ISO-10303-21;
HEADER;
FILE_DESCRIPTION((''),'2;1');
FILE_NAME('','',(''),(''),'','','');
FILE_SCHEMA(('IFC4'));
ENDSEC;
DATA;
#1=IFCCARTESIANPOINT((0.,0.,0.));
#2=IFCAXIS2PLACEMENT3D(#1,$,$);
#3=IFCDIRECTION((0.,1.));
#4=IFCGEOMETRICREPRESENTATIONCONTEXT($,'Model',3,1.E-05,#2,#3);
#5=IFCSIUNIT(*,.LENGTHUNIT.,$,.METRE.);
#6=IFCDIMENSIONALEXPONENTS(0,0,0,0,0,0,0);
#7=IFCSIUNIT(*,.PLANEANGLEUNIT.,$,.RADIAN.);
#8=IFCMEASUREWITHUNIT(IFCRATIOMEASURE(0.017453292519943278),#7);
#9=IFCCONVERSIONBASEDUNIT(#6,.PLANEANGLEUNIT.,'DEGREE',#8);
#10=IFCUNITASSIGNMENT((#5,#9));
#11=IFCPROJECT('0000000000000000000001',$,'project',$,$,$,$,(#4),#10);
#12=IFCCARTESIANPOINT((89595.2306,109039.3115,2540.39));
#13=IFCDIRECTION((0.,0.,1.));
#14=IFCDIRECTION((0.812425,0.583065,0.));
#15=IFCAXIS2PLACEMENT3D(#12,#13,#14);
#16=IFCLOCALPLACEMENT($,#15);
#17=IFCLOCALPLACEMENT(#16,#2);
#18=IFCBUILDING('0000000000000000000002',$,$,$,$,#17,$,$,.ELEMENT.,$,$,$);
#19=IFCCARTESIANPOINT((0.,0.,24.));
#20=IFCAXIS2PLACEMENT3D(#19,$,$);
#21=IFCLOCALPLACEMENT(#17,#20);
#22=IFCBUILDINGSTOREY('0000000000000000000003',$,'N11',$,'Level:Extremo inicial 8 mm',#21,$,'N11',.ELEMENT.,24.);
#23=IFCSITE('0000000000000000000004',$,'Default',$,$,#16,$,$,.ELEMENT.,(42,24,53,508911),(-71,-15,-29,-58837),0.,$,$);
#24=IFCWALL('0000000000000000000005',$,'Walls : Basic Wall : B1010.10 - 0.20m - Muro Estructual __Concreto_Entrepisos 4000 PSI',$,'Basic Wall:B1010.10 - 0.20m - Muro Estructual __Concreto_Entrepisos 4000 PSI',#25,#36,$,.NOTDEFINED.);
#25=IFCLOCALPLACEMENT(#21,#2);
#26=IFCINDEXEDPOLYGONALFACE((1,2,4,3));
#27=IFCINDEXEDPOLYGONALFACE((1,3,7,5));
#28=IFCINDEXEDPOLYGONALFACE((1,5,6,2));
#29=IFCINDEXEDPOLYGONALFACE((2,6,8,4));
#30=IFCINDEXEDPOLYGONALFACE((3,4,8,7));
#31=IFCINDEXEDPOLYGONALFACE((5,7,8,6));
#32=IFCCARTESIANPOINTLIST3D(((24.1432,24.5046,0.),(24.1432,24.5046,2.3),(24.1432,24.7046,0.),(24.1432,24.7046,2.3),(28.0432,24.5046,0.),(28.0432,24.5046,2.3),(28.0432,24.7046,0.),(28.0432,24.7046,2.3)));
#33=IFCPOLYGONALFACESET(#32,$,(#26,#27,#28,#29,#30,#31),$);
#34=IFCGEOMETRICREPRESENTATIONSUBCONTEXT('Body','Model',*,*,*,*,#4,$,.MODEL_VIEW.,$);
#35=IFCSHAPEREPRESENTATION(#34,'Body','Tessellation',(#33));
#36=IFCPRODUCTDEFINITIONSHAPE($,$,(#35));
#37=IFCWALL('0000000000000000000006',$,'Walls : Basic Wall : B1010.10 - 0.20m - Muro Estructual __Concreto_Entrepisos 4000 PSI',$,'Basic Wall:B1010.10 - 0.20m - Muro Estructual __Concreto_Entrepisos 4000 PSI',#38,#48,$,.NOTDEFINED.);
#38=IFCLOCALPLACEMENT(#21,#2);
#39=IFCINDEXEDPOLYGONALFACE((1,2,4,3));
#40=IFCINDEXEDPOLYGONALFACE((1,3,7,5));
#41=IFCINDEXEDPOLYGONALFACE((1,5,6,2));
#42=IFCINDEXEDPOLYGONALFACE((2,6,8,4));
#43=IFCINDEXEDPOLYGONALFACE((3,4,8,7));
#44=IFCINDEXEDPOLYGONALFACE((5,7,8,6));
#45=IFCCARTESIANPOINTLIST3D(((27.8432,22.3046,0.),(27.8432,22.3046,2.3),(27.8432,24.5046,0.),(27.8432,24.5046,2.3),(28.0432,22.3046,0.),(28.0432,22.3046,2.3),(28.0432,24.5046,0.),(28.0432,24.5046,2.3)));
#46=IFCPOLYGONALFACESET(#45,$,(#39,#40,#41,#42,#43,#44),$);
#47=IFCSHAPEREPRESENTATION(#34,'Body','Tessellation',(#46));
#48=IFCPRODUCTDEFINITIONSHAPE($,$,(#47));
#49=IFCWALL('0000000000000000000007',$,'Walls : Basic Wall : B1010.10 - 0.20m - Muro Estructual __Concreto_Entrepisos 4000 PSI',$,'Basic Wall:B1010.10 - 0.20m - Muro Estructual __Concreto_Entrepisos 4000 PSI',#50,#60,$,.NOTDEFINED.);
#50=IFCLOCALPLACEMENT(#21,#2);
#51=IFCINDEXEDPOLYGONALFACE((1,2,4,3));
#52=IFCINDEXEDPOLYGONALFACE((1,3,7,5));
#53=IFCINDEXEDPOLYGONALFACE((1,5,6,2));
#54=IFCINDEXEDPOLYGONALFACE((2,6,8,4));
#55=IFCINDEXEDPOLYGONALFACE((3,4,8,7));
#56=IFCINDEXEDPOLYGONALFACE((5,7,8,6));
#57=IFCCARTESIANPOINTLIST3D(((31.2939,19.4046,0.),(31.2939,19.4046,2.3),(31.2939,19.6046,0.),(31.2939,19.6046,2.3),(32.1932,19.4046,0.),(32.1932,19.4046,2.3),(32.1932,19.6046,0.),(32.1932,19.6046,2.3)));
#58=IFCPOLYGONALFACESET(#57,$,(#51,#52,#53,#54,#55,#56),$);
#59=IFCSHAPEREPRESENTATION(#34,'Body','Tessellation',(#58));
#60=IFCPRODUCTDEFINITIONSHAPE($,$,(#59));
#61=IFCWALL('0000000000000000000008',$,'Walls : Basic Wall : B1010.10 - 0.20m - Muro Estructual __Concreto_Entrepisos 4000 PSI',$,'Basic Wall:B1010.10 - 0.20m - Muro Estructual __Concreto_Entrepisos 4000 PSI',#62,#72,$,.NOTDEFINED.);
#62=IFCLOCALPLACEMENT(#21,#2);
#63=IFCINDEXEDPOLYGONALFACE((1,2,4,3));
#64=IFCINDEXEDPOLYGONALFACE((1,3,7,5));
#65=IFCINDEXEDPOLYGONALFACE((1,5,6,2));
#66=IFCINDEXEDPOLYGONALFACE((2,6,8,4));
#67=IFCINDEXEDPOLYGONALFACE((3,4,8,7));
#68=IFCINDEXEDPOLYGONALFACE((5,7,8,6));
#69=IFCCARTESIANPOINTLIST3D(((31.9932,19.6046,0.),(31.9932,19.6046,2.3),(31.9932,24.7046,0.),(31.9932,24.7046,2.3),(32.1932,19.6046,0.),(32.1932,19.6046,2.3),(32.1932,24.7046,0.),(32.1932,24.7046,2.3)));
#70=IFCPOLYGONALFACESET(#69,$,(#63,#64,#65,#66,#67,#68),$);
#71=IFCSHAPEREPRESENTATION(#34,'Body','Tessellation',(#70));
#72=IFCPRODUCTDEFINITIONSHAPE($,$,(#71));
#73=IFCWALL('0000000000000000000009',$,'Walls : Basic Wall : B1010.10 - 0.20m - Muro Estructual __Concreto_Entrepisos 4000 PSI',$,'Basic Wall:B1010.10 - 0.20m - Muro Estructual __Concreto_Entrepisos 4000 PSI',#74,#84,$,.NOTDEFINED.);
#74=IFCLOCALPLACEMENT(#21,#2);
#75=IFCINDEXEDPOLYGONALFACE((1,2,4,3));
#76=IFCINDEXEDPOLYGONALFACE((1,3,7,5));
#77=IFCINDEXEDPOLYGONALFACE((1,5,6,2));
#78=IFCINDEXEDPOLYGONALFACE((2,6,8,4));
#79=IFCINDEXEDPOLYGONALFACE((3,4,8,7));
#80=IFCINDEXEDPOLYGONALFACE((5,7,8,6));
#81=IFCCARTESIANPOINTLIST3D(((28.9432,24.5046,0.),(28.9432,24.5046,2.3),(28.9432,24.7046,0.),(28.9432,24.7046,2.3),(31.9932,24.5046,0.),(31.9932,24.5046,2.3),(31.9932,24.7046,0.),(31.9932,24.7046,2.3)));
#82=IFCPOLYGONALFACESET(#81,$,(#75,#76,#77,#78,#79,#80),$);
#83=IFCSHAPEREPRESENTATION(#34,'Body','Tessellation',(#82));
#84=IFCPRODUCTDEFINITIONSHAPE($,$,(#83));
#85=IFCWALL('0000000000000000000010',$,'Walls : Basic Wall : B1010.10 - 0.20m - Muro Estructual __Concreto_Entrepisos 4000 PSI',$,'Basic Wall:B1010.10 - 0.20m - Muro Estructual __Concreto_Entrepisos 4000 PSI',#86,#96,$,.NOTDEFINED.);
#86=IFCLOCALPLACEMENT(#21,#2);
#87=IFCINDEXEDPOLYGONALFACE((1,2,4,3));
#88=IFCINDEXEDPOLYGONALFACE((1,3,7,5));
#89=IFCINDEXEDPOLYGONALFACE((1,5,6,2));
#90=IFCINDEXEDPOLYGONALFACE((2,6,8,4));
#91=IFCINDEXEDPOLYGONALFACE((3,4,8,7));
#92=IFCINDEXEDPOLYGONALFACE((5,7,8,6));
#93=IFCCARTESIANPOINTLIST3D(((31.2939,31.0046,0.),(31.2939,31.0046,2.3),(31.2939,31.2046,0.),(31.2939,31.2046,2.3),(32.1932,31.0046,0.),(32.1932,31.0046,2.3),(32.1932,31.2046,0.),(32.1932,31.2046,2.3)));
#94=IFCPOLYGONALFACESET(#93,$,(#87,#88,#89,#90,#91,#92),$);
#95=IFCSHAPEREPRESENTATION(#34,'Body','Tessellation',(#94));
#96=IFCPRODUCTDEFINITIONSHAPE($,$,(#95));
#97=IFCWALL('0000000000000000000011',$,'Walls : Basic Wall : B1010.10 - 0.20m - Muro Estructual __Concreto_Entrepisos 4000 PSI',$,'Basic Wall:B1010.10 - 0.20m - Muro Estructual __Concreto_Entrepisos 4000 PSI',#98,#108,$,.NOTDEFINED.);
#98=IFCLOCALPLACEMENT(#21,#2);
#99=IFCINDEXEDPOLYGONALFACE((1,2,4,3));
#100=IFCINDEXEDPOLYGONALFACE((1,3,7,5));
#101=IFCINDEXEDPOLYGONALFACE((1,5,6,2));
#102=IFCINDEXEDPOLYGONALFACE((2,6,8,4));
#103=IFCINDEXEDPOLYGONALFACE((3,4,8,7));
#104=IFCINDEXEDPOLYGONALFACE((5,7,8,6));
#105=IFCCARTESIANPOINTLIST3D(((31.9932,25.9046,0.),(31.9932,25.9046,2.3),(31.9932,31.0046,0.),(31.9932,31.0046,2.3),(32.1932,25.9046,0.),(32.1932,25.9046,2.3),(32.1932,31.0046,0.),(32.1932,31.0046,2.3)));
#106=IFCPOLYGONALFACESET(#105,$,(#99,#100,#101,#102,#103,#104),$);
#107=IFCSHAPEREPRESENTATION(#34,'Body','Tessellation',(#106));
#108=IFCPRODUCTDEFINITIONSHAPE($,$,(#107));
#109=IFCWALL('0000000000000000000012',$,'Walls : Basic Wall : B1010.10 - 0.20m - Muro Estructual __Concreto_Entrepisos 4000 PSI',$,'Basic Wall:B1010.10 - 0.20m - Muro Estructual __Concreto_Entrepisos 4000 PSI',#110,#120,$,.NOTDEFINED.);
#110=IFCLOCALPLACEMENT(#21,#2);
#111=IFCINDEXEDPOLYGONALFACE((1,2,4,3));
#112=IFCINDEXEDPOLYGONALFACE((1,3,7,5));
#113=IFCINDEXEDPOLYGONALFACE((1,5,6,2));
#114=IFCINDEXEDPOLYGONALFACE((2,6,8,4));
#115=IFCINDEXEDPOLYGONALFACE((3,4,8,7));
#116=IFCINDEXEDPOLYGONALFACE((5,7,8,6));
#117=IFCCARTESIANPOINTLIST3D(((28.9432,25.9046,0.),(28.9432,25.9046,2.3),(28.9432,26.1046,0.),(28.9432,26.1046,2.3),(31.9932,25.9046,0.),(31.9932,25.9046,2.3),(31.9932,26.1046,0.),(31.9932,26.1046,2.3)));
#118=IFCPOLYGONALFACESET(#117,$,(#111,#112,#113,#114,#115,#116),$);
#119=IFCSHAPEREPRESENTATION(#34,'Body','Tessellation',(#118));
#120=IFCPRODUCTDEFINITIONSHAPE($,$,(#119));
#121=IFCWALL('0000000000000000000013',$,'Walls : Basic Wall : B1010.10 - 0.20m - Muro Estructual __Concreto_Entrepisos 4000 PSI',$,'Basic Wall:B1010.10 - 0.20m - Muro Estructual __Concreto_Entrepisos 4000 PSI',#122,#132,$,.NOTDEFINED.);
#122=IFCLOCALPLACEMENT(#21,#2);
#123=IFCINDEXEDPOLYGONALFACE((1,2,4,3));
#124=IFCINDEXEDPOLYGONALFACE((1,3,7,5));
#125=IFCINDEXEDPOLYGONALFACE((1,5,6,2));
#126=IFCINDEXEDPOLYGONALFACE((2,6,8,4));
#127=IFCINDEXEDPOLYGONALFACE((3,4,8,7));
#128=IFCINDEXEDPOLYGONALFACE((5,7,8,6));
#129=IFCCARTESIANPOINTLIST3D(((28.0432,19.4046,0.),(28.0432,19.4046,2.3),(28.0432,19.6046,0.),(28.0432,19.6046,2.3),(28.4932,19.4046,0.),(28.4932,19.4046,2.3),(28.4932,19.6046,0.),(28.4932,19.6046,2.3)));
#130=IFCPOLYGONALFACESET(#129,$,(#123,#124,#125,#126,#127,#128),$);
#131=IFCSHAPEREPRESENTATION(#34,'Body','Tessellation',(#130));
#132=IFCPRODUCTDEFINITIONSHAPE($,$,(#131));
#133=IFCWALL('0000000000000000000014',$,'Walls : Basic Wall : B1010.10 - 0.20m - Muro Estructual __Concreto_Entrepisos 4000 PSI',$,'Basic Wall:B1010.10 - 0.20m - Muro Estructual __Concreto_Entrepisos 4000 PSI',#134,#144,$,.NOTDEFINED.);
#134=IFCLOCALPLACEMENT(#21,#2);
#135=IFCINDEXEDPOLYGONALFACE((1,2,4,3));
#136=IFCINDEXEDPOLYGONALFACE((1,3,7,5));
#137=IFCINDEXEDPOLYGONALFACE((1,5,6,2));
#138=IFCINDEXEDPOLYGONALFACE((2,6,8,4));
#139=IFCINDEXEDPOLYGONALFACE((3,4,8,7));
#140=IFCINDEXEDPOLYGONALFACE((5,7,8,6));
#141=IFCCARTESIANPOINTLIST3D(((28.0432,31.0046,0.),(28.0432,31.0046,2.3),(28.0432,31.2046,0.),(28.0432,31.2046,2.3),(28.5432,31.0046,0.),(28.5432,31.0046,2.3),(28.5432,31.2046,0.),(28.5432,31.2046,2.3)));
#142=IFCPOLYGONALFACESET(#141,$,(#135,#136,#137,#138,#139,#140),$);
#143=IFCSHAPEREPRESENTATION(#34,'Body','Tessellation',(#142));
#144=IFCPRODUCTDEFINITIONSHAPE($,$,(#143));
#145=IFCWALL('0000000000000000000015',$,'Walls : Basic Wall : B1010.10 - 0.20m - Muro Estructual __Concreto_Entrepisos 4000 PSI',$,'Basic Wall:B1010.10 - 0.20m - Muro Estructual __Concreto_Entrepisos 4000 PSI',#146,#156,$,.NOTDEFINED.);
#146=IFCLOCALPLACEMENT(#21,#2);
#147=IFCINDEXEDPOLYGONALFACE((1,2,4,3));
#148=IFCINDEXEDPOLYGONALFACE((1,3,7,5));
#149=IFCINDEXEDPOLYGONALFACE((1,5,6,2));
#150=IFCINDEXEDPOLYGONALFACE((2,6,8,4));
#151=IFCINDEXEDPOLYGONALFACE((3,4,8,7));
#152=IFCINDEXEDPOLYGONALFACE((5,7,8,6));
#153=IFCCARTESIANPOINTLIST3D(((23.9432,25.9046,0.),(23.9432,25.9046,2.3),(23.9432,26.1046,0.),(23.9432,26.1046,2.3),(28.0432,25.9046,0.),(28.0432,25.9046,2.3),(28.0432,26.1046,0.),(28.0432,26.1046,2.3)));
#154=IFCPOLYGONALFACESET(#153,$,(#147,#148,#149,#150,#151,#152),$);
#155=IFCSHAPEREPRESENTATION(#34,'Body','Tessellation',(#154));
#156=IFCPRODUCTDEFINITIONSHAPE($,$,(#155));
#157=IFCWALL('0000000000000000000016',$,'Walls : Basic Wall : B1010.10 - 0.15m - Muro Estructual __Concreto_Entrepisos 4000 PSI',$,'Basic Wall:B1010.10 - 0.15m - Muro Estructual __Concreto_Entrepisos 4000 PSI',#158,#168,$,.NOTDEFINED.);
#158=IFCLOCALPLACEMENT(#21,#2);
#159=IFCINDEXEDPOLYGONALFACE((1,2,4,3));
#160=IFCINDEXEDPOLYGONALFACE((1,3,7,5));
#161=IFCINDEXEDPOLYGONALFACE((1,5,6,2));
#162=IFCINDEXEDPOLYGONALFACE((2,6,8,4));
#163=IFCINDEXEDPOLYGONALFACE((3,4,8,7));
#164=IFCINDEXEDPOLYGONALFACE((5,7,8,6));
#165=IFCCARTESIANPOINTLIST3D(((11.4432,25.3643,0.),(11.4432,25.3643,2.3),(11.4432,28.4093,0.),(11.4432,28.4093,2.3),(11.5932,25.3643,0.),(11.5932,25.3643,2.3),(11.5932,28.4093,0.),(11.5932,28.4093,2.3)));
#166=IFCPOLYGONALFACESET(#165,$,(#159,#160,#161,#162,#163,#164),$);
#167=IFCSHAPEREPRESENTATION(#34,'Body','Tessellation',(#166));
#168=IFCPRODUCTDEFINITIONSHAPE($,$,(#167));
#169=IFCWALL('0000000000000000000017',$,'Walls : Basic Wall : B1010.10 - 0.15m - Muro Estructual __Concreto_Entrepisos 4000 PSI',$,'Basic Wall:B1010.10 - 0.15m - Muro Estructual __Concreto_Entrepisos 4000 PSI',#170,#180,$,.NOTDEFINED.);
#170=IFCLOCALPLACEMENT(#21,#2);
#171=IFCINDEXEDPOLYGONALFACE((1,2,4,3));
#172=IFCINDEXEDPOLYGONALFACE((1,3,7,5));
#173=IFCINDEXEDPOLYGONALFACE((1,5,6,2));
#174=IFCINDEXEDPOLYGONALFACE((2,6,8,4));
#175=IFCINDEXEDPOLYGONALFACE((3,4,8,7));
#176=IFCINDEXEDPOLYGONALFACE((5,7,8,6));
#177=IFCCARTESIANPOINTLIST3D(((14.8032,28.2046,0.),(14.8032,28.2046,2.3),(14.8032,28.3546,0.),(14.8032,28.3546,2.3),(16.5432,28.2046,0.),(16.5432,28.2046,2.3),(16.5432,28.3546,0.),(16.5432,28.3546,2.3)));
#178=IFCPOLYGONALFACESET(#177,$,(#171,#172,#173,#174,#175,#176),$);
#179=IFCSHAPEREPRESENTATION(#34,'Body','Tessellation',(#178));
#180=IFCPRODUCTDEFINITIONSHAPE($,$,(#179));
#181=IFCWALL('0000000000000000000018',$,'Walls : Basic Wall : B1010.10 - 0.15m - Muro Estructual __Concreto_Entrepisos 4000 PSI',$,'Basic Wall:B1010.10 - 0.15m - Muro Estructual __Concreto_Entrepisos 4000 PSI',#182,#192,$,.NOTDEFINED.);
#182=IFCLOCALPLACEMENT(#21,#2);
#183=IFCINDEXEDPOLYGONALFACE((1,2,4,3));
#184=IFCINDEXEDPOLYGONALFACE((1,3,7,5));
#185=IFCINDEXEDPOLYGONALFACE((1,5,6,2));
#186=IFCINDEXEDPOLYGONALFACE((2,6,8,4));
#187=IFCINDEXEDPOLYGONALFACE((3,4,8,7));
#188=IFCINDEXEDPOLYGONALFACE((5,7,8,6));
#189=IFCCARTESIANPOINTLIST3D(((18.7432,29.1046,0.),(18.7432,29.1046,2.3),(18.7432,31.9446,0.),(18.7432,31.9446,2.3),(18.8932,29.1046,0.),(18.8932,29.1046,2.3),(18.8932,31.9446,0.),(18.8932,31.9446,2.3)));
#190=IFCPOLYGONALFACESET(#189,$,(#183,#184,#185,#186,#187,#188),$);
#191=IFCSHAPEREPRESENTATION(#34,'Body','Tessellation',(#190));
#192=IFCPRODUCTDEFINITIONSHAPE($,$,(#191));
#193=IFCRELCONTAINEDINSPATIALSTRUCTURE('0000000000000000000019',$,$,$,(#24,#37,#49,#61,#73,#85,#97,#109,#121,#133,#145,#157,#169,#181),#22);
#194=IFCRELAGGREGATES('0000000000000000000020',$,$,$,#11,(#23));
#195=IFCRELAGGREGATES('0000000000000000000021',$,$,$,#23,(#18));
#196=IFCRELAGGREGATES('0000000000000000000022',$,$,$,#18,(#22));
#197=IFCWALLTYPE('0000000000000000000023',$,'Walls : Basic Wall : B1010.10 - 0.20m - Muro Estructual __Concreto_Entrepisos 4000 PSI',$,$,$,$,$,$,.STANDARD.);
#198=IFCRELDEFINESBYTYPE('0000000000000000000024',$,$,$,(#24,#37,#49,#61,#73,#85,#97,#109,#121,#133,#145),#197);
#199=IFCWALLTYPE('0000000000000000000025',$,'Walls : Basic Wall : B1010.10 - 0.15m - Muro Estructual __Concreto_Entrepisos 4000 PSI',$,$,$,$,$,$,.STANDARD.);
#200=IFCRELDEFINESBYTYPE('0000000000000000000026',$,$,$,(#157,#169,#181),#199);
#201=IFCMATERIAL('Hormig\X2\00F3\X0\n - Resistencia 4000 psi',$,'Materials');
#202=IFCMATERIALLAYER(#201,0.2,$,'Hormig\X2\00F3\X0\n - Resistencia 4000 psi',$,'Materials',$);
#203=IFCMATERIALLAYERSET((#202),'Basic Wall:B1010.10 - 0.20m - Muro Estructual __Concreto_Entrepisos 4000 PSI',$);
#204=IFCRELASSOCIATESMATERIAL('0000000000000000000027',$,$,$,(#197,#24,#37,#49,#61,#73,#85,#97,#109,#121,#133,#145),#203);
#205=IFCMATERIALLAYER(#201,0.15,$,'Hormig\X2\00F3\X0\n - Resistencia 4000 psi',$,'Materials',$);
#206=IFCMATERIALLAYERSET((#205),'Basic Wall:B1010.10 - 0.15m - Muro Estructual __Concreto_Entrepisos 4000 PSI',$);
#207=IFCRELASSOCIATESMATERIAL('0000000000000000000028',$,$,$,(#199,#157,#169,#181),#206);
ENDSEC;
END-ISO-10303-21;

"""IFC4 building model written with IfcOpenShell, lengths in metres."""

from ifc_helpers import new_model, entity, si_unit, converted_unit, direction, frame, frame_2d, origin, place, context, subcontext, project, spatial, rectangle, extrude, material, layer, layer_set, layer_usage, type_object, element, save


model = new_model("IFC4")

# Units and contexts
model_context = context("Model", 3, precision=1e-05, world=origin(), true_north=direction((0.0, 1.0)))
body_context = subcontext(model_context, "Body", "Model", "MODEL_VIEW")
ifc_project = project(units=[si_unit("LENGTHUNIT", "METRE"), converted_unit("PLANEANGLEUNIT", "DEGREE", entity("IfcRatioMeasure", 0.017453292519943278), si_unit("PLANEANGLEUNIT", "RADIAN"), dimensions=[0, 0, 0, 0, 0, 0, 0])], contexts=[model_context])

# Site, building, storey
site_placement = place(None, frame((89595.2306, 109039.3115, 2540.39), z_axis=(0.0, 0.0, 1.0), x_axis=(0.812425, 0.583065, 0.0)))
site = spatial("IfcSite", under=ifc_project, at=site_placement, Name="Default", CompositionType="ELEMENT", RefLatitude=(42, 24, 53, 508911), RefLongitude=(-71, -15, -29, -58837), RefElevation=0.0)
building_placement = place(site_placement, origin())
building = spatial("IfcBuilding", under=site, at=building_placement, CompositionType="ELEMENT")
storey_placement = place(building_placement, frame((0.0, 0.0, 24.0)))
storey = spatial("IfcBuildingStorey", under=building, at=storey_placement, Name="N11", ObjectType="Level:Extremo inicial 8 mm", LongName="N11", CompositionType="ELEMENT", Elevation=24.0)

# Walls
ifc_material_1 = material(Name="Hormigón - Resistencia 4000 psi", Category="Materials")
ifc_layer_1 = layer(ifc_material_1, 0.2, Name="Hormigón - Resistencia 4000 psi", Category="Materials")
ifc_layer_set_1 = layer_set([ifc_layer_1], Name="Basic Wall:B1010.10 - 0.20m - Muro Estructual __Concreto_Entrepisos 4000 PSI")
wall_type_1 = type_object("IfcWallType", Name="Walls : Basic Wall : B1010.10 - 0.20m - Muro Estructual __Concreto_Entrepisos 4000 PSI", PredefinedType="STANDARD", material=ifc_layer_set_1)
ifc_layer_usage_1 = layer_usage(ifc_layer_set_1, "AXIS2", "NEGATIVE", 0.1)
wall_1_placement = place(storey_placement, frame((24.1432, 24.6046, 0.0)))
element("IfcWall", 1, at=wall_1_placement, inside=storey, type_object=wall_type_1, material=ifc_layer_usage_1, Name="Walls : Basic Wall : B1010.10 - 0.20m - Muro Estructual __Concreto_Entrepisos 4000 PSI", ObjectType="Basic Wall:B1010.10 - 0.20m - Muro Estructual __Concreto_Entrepisos 4000 PSI", PredefinedType="NOTDEFINED", context=body_context, shape_type="SweptSolid", body=[
    extrude(rectangle(XDim=3.9, YDim=0.2, at=frame_2d((1.95, 0.0), x_axis=(-1.0, 0.0))), origin(), (0.0, 0.0, 1.0), 2.3),
])
ifc_layer_usage_2 = layer_usage(ifc_layer_set_1, "AXIS2", "NEGATIVE", 0.1)
wall_2_placement = place(storey_placement, frame((27.9432, 24.5046, 0.0), z_axis=(0.0, 0.0, 1.0), x_axis=(0.0, -1.0, 0.0)))
element("IfcWall", 2, at=wall_2_placement, inside=storey, type_object=wall_type_1, material=ifc_layer_usage_2, Name="Walls : Basic Wall : B1010.10 - 0.20m - Muro Estructual __Concreto_Entrepisos 4000 PSI", ObjectType="Basic Wall:B1010.10 - 0.20m - Muro Estructual __Concreto_Entrepisos 4000 PSI", PredefinedType="NOTDEFINED", context=body_context, shape_type="SweptSolid", body=[
    extrude(rectangle(XDim=2.2, YDim=0.2, at=frame_2d((1.1, 0.0), x_axis=(-1.0, 0.0))), origin(), (0.0, 0.0, 1.0), 2.3),
])
ifc_layer_usage_3 = layer_usage(ifc_layer_set_1, "AXIS2", "NEGATIVE", 0.1)
wall_3_placement = place(storey_placement, frame((31.2939, 19.5046, 0.0)))
element("IfcWall", 3, at=wall_3_placement, inside=storey, type_object=wall_type_1, material=ifc_layer_usage_3, Name="Walls : Basic Wall : B1010.10 - 0.20m - Muro Estructual __Concreto_Entrepisos 4000 PSI", ObjectType="Basic Wall:B1010.10 - 0.20m - Muro Estructual __Concreto_Entrepisos 4000 PSI", PredefinedType="NOTDEFINED", context=body_context, shape_type="SweptSolid", body=[
    extrude(rectangle(XDim=0.8993, YDim=0.2, at=frame_2d((0.4497, 0.0), x_axis=(-1.0, 0.0))), origin(), (0.0, 0.0, 1.0), 2.3),
])
ifc_layer_usage_4 = layer_usage(ifc_layer_set_1, "AXIS2", "NEGATIVE", 0.1)
wall_4_placement = place(storey_placement, frame((32.0932, 19.6046, 0.0), z_axis=(0.0, 0.0, 1.0), x_axis=(0.0, 1.0, 0.0)))
element("IfcWall", 4, at=wall_4_placement, inside=storey, type_object=wall_type_1, material=ifc_layer_usage_4, Name="Walls : Basic Wall : B1010.10 - 0.20m - Muro Estructual __Concreto_Entrepisos 4000 PSI", ObjectType="Basic Wall:B1010.10 - 0.20m - Muro Estructual __Concreto_Entrepisos 4000 PSI", PredefinedType="NOTDEFINED", context=body_context, shape_type="SweptSolid", body=[
    extrude(rectangle(XDim=5.1, YDim=0.2, at=frame_2d((2.55, 0.0), x_axis=(-1.0, 0.0))), origin(), (0.0, 0.0, 1.0), 2.3),
])
ifc_layer_usage_5 = layer_usage(ifc_layer_set_1, "AXIS2", "NEGATIVE", 0.1)
wall_5_placement = place(storey_placement, frame((31.9932, 24.6046, 0.0), z_axis=(0.0, 0.0, 1.0), x_axis=(-1.0, 0.0, 0.0)))
element("IfcWall", 5, at=wall_5_placement, inside=storey, type_object=wall_type_1, material=ifc_layer_usage_5, Name="Walls : Basic Wall : B1010.10 - 0.20m - Muro Estructual __Concreto_Entrepisos 4000 PSI", ObjectType="Basic Wall:B1010.10 - 0.20m - Muro Estructual __Concreto_Entrepisos 4000 PSI", PredefinedType="NOTDEFINED", context=body_context, shape_type="SweptSolid", body=[
    extrude(rectangle(XDim=3.05, YDim=0.2, at=frame_2d((1.525, 0.0), x_axis=(-1.0, 0.0))), origin(), (0.0, 0.0, 1.0), 2.3),
])
ifc_layer_usage_6 = layer_usage(ifc_layer_set_1, "AXIS2", "POSITIVE", -0.1)
wall_6_placement = place(storey_placement, frame((31.2939, 31.1046, 0.0)))
element("IfcWall", 6, at=wall_6_placement, inside=storey, type_object=wall_type_1, material=ifc_layer_usage_6, Name="Walls : Basic Wall : B1010.10 - 0.20m - Muro Estructual __Concreto_Entrepisos 4000 PSI", ObjectType="Basic Wall:B1010.10 - 0.20m - Muro Estructual __Concreto_Entrepisos 4000 PSI", PredefinedType="NOTDEFINED", context=body_context, shape_type="SweptSolid", body=[
    extrude(rectangle(XDim=0.8993, YDim=0.2, at=frame_2d((0.4497, 0.0), x_axis=(-1.0, 0.0))), origin(), (0.0, 0.0, 1.0), 2.3),
])
ifc_layer_usage_7 = layer_usage(ifc_layer_set_1, "AXIS2", "POSITIVE", -0.1)
wall_7_placement = place(storey_placement, frame((32.0932, 31.0046, 0.0), z_axis=(0.0, 0.0, 1.0), x_axis=(0.0, -1.0, 0.0)))
element("IfcWall", 7, at=wall_7_placement, inside=storey, type_object=wall_type_1, material=ifc_layer_usage_7, Name="Walls : Basic Wall : B1010.10 - 0.20m - Muro Estructual __Concreto_Entrepisos 4000 PSI", ObjectType="Basic Wall:B1010.10 - 0.20m - Muro Estructual __Concreto_Entrepisos 4000 PSI", PredefinedType="NOTDEFINED", context=body_context, shape_type="SweptSolid", body=[
    extrude(rectangle(XDim=5.1, YDim=0.2, at=frame_2d((2.55, 0.0), x_axis=(-1.0, 0.0))), origin(), (0.0, 0.0, 1.0), 2.3),
])
ifc_layer_usage_8 = layer_usage(ifc_layer_set_1, "AXIS2", "POSITIVE", -0.1)
wall_8_placement = place(storey_placement, frame((31.9932, 26.0046, 0.0), z_axis=(0.0, 0.0, 1.0), x_axis=(-1.0, 0.0, 0.0)))
element("IfcWall", 8, at=wall_8_placement, inside=storey, type_object=wall_type_1, material=ifc_layer_usage_8, Name="Walls : Basic Wall : B1010.10 - 0.20m - Muro Estructual __Concreto_Entrepisos 4000 PSI", ObjectType="Basic Wall:B1010.10 - 0.20m - Muro Estructual __Concreto_Entrepisos 4000 PSI", PredefinedType="NOTDEFINED", context=body_context, shape_type="SweptSolid", body=[
    extrude(rectangle(XDim=3.05, YDim=0.2, at=frame_2d((1.525, 0.0), x_axis=(-1.0, 0.0))), origin(), (0.0, 0.0, 1.0), 2.3),
])
ifc_layer_usage_9 = layer_usage(ifc_layer_set_1, "AXIS2", "NEGATIVE", 0.1)
wall_9_placement = place(storey_placement, frame((28.4932, 19.5046, 0.0), z_axis=(0.0, 0.0, 1.0), x_axis=(-1.0, 0.0, 0.0)))
element("IfcWall", 9, at=wall_9_placement, inside=storey, type_object=wall_type_1, material=ifc_layer_usage_9, Name="Walls : Basic Wall : B1010.10 - 0.20m - Muro Estructual __Concreto_Entrepisos 4000 PSI", ObjectType="Basic Wall:B1010.10 - 0.20m - Muro Estructual __Concreto_Entrepisos 4000 PSI", PredefinedType="NOTDEFINED", context=body_context, shape_type="SweptSolid", body=[
    extrude(rectangle(XDim=0.45, YDim=0.2, at=frame_2d((0.225, 0.0), x_axis=(-1.0, 0.0))), origin(), (0.0, 0.0, 1.0), 2.3),
])
ifc_layer_usage_10 = layer_usage(ifc_layer_set_1, "AXIS2", "NEGATIVE", 0.1)
wall_10_placement = place(storey_placement, frame((28.5432, 31.1046, 0.0), z_axis=(0.0, 0.0, 1.0), x_axis=(-1.0, 0.0, 0.0)))
element("IfcWall", 10, at=wall_10_placement, inside=storey, type_object=wall_type_1, material=ifc_layer_usage_10, Name="Walls : Basic Wall : B1010.10 - 0.20m - Muro Estructual __Concreto_Entrepisos 4000 PSI", ObjectType="Basic Wall:B1010.10 - 0.20m - Muro Estructual __Concreto_Entrepisos 4000 PSI", PredefinedType="NOTDEFINED", context=body_context, shape_type="SweptSolid", body=[
    extrude(rectangle(XDim=0.5, YDim=0.2, at=frame_2d((0.25, 0.0), x_axis=(-1.0, 0.0))), origin(), (0.0, 0.0, 1.0), 2.3),
])
ifc_layer_usage_11 = layer_usage(ifc_layer_set_1, "AXIS2", "NEGATIVE", 0.1)
wall_11_placement = place(storey_placement, frame((23.9432, 26.0046, 0.0)))
element("IfcWall", 11, at=wall_11_placement, inside=storey, type_object=wall_type_1, material=ifc_layer_usage_11, Name="Walls : Basic Wall : B1010.10 - 0.20m - Muro Estructual __Concreto_Entrepisos 4000 PSI", ObjectType="Basic Wall:B1010.10 - 0.20m - Muro Estructual __Concreto_Entrepisos 4000 PSI", PredefinedType="NOTDEFINED", context=body_context, shape_type="SweptSolid", body=[
    extrude(rectangle(XDim=4.1, YDim=0.2, at=frame_2d((2.05, 0.0), x_axis=(-1.0, 0.0))), origin(), (0.0, 0.0, 1.0), 2.3),
])
ifc_layer_2 = layer(ifc_material_1, 0.15, Name="Hormigón - Resistencia 4000 psi", Category="Materials")
ifc_layer_set_2 = layer_set([ifc_layer_2], Name="Basic Wall:B1010.10 - 0.15m - Muro Estructual __Concreto_Entrepisos 4000 PSI")
ifc_layer_usage_12 = layer_usage(ifc_layer_set_2, "AXIS2", "NEGATIVE", 0.075)
wall_type_2 = type_object("IfcWallType", Name="Walls : Basic Wall : B1010.10 - 0.15m - Muro Estructual __Concreto_Entrepisos 4000 PSI", PredefinedType="STANDARD", material=ifc_layer_set_2)
wall_12_placement = place(storey_placement, frame((11.5182, 25.3643, 0.0), z_axis=(0.0, 0.0, 1.0), x_axis=(0.0, 1.0, 0.0)))
element("IfcWall", 12, at=wall_12_placement, inside=storey, type_object=wall_type_2, material=ifc_layer_usage_12, Name="Walls : Basic Wall : B1010.10 - 0.15m - Muro Estructual __Concreto_Entrepisos 4000 PSI", ObjectType="Basic Wall:B1010.10 - 0.15m - Muro Estructual __Concreto_Entrepisos 4000 PSI", PredefinedType="NOTDEFINED", context=body_context, shape_type="SweptSolid", body=[
    extrude(rectangle(XDim=3.045, YDim=0.15, at=frame_2d((1.5225, 0.0), x_axis=(-1.0, 0.0))), origin(), (0.0, 0.0, 1.0), 2.3),
])
ifc_layer_usage_13 = layer_usage(ifc_layer_set_2, "AXIS2", "NEGATIVE", 0.075)
wall_13_placement = place(storey_placement, frame((16.5432, 28.2796, 0.0), z_axis=(0.0, 0.0, 1.0), x_axis=(-1.0, 0.0, 0.0)))
element("IfcWall", 13, at=wall_13_placement, inside=storey, type_object=wall_type_2, material=ifc_layer_usage_13, Name="Walls : Basic Wall : B1010.10 - 0.15m - Muro Estructual __Concreto_Entrepisos 4000 PSI", ObjectType="Basic Wall:B1010.10 - 0.15m - Muro Estructual __Concreto_Entrepisos 4000 PSI", PredefinedType="NOTDEFINED", context=body_context, shape_type="SweptSolid", body=[
    extrude(rectangle(XDim=1.74, YDim=0.15, at=frame_2d((0.87, 0.0), x_axis=(-1.0, 0.0))), origin(), (0.0, 0.0, 1.0), 2.3),
])
ifc_layer_usage_14 = layer_usage(ifc_layer_set_2, "AXIS2", "NEGATIVE", 0.075)
wall_14_placement = place(storey_placement, frame((18.8182, 31.9446, 0.0), z_axis=(0.0, 0.0, 1.0), x_axis=(0.0, -1.0, 0.0)))
element("IfcWall", 14, at=wall_14_placement, inside=storey, type_object=wall_type_2, material=ifc_layer_usage_14, Name="Walls : Basic Wall : B1010.10 - 0.15m - Muro Estructual __Concreto_Entrepisos 4000 PSI", ObjectType="Basic Wall:B1010.10 - 0.15m - Muro Estructual __Concreto_Entrepisos 4000 PSI", PredefinedType="NOTDEFINED", context=body_context, shape_type="SweptSolid", body=[
    extrude(rectangle(XDim=2.84, YDim=0.15, at=frame_2d((1.42, 0.0), x_axis=(-1.0, 0.0))), origin(), (0.0, 0.0, 1.0), 2.3),
])

save(model, "model.ifc")
